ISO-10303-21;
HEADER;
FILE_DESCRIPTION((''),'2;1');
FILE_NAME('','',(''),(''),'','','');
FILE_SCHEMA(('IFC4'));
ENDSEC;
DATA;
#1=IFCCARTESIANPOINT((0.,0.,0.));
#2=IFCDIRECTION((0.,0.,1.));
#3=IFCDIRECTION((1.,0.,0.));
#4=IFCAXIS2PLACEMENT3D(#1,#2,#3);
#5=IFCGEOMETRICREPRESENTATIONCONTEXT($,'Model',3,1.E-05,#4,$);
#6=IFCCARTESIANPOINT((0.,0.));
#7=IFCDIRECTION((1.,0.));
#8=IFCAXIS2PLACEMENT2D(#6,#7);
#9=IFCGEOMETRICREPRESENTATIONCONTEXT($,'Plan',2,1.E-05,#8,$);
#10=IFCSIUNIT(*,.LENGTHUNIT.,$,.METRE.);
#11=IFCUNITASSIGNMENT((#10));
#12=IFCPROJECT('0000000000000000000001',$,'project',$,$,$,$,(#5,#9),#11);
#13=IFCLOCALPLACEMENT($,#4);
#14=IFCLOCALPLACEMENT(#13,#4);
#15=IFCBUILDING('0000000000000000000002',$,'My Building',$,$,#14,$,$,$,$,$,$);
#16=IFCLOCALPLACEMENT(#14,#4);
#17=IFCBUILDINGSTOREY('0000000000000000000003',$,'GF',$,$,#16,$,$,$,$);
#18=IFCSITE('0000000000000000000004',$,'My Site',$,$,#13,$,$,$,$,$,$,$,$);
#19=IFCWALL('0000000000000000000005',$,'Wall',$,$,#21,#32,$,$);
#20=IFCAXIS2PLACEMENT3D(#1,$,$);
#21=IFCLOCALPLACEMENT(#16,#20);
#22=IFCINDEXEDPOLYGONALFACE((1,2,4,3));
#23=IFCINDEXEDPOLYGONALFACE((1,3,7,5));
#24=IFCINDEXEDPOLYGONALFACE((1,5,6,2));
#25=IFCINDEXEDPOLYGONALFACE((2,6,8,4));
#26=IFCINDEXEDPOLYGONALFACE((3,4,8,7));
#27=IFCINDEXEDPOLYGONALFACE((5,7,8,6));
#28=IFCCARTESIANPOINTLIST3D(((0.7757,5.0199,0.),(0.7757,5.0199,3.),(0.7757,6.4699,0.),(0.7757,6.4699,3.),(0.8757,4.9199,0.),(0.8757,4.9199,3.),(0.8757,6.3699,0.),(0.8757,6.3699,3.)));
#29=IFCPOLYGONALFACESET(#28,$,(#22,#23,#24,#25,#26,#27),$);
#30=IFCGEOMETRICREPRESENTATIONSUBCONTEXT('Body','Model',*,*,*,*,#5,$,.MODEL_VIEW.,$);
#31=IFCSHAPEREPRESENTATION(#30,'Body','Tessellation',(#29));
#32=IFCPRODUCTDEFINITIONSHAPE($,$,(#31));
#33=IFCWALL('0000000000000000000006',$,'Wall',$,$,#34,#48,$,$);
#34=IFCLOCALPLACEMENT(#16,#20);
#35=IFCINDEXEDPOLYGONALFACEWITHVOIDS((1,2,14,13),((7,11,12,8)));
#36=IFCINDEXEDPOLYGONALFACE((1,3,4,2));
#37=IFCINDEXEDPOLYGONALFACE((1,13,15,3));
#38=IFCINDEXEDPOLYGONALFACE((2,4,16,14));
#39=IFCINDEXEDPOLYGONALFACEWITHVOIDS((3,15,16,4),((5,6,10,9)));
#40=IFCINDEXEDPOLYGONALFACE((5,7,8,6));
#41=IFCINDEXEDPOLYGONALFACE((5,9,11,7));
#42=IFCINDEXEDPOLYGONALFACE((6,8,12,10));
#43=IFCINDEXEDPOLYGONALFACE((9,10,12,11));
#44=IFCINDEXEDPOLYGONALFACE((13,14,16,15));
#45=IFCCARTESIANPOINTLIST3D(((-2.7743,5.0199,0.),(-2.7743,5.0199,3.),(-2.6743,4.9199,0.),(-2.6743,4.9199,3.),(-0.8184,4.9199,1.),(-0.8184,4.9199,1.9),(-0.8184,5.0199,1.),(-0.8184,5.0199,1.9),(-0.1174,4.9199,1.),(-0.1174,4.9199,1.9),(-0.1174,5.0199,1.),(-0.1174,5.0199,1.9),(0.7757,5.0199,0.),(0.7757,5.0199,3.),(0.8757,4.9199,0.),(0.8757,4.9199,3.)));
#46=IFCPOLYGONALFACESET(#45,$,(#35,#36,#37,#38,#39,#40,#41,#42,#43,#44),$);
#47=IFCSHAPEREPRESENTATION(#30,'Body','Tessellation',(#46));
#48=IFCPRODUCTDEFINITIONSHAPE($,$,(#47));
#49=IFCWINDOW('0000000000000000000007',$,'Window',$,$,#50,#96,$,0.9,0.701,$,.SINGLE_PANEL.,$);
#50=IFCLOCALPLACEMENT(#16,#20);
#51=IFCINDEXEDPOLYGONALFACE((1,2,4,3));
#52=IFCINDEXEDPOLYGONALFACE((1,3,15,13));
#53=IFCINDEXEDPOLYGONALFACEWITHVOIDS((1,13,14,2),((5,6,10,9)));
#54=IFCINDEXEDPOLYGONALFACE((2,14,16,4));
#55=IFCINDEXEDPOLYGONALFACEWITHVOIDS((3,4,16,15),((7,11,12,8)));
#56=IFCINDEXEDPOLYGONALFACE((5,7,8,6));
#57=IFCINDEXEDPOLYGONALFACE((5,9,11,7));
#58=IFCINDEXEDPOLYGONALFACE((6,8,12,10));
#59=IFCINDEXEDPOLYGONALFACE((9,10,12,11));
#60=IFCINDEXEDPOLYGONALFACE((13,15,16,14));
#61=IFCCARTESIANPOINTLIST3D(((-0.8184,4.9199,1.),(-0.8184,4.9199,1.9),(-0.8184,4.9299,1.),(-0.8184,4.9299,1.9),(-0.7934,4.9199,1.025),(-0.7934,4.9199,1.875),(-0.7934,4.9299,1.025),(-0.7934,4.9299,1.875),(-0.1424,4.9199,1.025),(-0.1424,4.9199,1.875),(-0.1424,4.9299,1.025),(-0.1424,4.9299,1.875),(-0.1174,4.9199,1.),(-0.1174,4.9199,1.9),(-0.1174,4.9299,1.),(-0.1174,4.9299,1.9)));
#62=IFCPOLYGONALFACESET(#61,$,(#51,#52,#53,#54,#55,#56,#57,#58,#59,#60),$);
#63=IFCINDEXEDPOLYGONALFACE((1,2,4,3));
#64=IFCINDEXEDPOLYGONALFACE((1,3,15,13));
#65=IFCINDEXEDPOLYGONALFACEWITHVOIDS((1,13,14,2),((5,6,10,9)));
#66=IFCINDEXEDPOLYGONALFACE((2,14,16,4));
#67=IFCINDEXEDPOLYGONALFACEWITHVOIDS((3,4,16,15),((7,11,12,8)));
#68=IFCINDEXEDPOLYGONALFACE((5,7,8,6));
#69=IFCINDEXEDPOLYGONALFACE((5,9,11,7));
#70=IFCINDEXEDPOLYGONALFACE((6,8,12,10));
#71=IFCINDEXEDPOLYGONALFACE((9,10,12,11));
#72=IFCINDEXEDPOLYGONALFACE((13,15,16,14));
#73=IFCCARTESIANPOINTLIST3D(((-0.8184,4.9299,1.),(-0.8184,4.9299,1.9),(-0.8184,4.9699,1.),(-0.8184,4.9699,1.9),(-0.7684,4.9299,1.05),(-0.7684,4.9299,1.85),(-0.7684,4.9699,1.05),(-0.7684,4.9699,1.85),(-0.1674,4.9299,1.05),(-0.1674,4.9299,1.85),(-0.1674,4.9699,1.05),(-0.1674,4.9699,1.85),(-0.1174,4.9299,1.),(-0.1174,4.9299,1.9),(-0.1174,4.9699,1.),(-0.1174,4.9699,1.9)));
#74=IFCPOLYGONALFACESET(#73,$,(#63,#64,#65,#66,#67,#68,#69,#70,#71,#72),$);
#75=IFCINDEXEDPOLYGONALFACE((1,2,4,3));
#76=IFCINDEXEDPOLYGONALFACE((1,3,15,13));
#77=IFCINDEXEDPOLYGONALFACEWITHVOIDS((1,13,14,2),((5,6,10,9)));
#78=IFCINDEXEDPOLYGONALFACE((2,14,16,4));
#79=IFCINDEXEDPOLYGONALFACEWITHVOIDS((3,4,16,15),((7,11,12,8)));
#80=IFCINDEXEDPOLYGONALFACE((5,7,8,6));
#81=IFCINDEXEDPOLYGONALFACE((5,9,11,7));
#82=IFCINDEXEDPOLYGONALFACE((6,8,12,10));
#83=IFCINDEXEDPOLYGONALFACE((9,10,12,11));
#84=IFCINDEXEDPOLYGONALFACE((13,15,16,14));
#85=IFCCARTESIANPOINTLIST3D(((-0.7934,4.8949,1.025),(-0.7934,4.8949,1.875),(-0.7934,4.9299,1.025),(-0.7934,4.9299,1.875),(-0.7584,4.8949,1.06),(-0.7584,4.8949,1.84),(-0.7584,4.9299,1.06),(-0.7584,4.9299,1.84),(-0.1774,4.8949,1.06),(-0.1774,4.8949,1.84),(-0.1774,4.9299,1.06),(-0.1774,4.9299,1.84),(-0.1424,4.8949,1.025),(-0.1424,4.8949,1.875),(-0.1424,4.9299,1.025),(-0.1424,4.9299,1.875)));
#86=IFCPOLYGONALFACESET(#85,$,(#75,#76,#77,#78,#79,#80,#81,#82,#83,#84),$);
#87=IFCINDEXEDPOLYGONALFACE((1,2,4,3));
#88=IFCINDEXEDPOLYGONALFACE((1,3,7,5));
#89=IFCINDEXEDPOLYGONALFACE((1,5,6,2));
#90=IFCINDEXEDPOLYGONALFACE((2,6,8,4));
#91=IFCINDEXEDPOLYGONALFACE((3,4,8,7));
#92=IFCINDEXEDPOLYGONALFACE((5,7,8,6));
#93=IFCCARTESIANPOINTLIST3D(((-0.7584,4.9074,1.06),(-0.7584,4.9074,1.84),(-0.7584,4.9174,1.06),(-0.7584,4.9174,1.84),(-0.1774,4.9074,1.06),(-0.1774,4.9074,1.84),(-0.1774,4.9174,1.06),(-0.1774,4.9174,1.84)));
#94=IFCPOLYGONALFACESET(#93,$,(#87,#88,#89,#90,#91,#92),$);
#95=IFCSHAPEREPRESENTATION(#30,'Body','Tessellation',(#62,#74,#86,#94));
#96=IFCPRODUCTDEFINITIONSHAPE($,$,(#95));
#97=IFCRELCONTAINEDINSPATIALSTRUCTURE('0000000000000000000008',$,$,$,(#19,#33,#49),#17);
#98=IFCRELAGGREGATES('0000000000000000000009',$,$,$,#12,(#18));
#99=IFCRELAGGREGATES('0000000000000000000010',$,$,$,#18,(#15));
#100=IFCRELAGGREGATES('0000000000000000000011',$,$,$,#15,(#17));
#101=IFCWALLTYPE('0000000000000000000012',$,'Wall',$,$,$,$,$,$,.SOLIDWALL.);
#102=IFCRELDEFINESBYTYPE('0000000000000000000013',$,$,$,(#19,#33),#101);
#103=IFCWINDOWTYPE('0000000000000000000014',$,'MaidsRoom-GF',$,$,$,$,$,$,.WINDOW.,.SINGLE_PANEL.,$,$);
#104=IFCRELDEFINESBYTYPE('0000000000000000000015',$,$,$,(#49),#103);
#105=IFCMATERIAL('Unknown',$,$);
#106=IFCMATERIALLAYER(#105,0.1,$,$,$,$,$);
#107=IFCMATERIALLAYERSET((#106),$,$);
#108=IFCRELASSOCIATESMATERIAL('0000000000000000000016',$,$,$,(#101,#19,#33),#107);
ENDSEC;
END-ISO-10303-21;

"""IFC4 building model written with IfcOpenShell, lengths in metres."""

from ifc_helpers import new_model, entity, si_unit, frame, origin_with_axes, origin_2d_with_axis, place, context, subcontext, project, spatial, line, indexed_curve, outline, extrude, shape, source, transform, mapped, material, layer, layer_set, layer_usage, type_object, type_shapes, element, fill, save


model = new_model("IFC4")

# Units and contexts
model_context = context("Model", 3, precision=1e-05, world=origin_with_axes())
plan_context = context("Plan", 2, precision=1e-05, world=origin_2d_with_axis())
body_context_1 = subcontext(model_context, "Body", "Model", "MODEL_VIEW")
body_context_2 = subcontext(plan_context, "Body", "Plan", "PLAN_VIEW")
ifc_project = project(units=[si_unit("LENGTHUNIT", "METRE")], contexts=[model_context, plan_context])

# Site, building, storey
site_placement = place(None, origin_with_axes())
site = spatial("IfcSite", under=ifc_project, at=site_placement, Name="My Site")
building_placement = place(site_placement, origin_with_axes())
building = spatial("IfcBuilding", under=site, at=building_placement, Name="My Building")
storey_placement = place(building_placement, origin_with_axes())
storey = spatial("IfcBuildingStorey", under=building, at=storey_placement, Name="GF")

# Shared definitions
ifc_material_1 = material(Name="Unknown")

# Wall
ifc_layer_1 = layer(ifc_material_1, 0.1)
ifc_layer_set_1 = layer_set([ifc_layer_1])
wall_type = type_object("IfcWallType", Name="Wall", PredefinedType="SOLIDWALL", material=ifc_layer_set_1)
ifc_layer_usage_1 = layer_usage(ifc_layer_set_1, "AXIS2", "POSITIVE", 0.0)
wall_1_placement = place(storey_placement, frame((0.7757, 6.4699, 0.0), z_axis=(0.0, 0.0, 1.0), x_axis=(0.0, -1.0, 0.0)))
element("IfcWall", 1, at=wall_1_placement, inside=storey, type_object=wall_type, material=ifc_layer_usage_1, Name="Wall", context=body_context_1, shape_type="SweptSolid", body=[
    extrude(outline(indexed_curve([(0.0, 0.0), (0.1, 0.1), (1.55, 0.1), (1.45, 0.0)], segments=[line(1, 2, 3, 4, 1)])), origin_with_axes(), (0.0, 0.0, 1.0), 3.0),
])

# Wall, opening, window
ifc_layer_usage_2 = layer_usage(ifc_layer_set_1, "AXIS2", "POSITIVE", 0.0)
wall_2_placement = place(storey_placement, frame((0.7757, 5.0199, 0.0), z_axis=(0.0, 0.0, 1.0), x_axis=(-1.0, 0.0, 0.0)))
wall_2 = element("IfcWall", 2, at=wall_2_placement, inside=storey, type_object=wall_type, material=ifc_layer_usage_2, Name="Wall", context=body_context_1, shape_type="SweptSolid", body=[
    extrude(outline(indexed_curve([(0.0, 0.0), (-0.1, 0.1), (3.45, 0.1), (3.55, 0.0)], segments=[line(1, 2, 3, 4, 1)])), origin_with_axes(), (0.0, 0.0, 1.0), 3.0),
])
shared_shape_1 = source(origin_with_axes(), body_context_1, "Body", "SweptSolid", [
    extrude(outline(indexed_curve([(0.0, 0.0), (0.701, 0.0), (0.701, 0.9), (0.0, 0.9)], segments=[line(1, 2, 3, 4, 1)])), frame((0.0, -0.6, 0.0), z_axis=(0.0, -1.0, 0.0), x_axis=(1.0, 0.0, 0.0)), (0.0, 0.0, -1.0), 1.2),
])
opening_1_placement = place(wall_2_placement, frame((0.8931, 0.0, 1.0), z_axis=(0.0, 0.0, 1.0), x_axis=(1.0, 0.0, 0.0)))
opening_1 = element("IfcOpeningElement", 3, at=opening_1_placement, cuts=wall_2, PredefinedType="OPENING", context=body_context_1, shape_type="MappedRepresentation", body=[
    mapped(shared_shape_1, transform((0.0, 0.0, 0.0), x_axis=(1.0, 0.0, 0.0), y_axis=(0.0, 1.0, 0.0), z_axis=(0.0, 0.0, 1.0), scale=1.0)),
])
window_type_1 = type_object("IfcWindowType", Name="MaidsRoom-GF", PartitioningType="SINGLE_PANEL", PredefinedType="WINDOW")
shared_shape_2 = source(origin_with_axes(), body_context_1, "Body", "SweptSolid", [
    extrude(outline(indexed_curve([(0.0, 0.0), (0.701, 0.0), (0.701, 0.9), (0.0, 0.9)], segments=[line(1, 2, 3, 4, 1)]), holes=[indexed_curve([(0.025, 0.025), (0.676, 0.025), (0.676, 0.875), (0.025, 0.875)], segments=[line(1, 2, 3, 4, 1)])]), frame((0.0, 0.09, 0.0), z_axis=(0.0, -1.0, 0.0), x_axis=(1.0, 0.0, 0.0)), (0.0, 0.0, -1.0), 0.01),
    extrude(outline(indexed_curve([(0.0, 0.0), (0.701, 0.0), (0.701, 0.9), (0.0, 0.9)], segments=[line(1, 2, 3, 4, 1)]), holes=[indexed_curve([(0.05, 0.05), (0.651, 0.05), (0.651, 0.85), (0.05, 0.85)], segments=[line(1, 2, 3, 4, 1)])]), frame((0.0, 0.05, 0.0), z_axis=(0.0, -1.0, 0.0), x_axis=(1.0, 0.0, 0.0)), (0.0, 0.0, -1.0), 0.04),
    extrude(outline(indexed_curve([(0.0, 0.0), (0.651, 0.0), (0.651, 0.85), (0.0, 0.85)], segments=[line(1, 2, 3, 4, 1)]), holes=[indexed_curve([(0.035, 0.035), (0.616, 0.035), (0.616, 0.815), (0.035, 0.815)], segments=[line(1, 2, 3, 4, 1)])]), frame((0.025, 0.09, 0.025), z_axis=(0.0, -1.0, 0.0), x_axis=(1.0, 0.0, 0.0)), (0.0, 0.0, -1.0), 0.035),
    extrude(outline(indexed_curve([(0.035, 0.035), (0.616, 0.035), (0.616, 0.815), (0.035, 0.815)], segments=[line(1, 2, 3, 4, 1)])), frame((0.025, 0.1025, 0.025), z_axis=(0.0, -1.0, 0.0), x_axis=(1.0, 0.0, 0.0)), (0.0, 0.0, -1.0), 0.01),
])
shared_shape_3 = source(origin_with_axes(), body_context_2, "Body", "Curve2D", [
    entity("IfcIndexedPolyCurve", entity("IfcCartesianPointList2D", [[0.05, 0.05], [0.651, 0.05]])),
    entity("IfcIndexedPolyCurve", entity("IfcCartesianPointList2D", [[0.0, 0.1], [0.025, 0.1], [0.025, 0.09], [0.05, 0.09], [0.05, 0.05], [0.0, 0.05]]), [entity("IfcLineIndex", [1, 2, 3, 4, 5, 6, 1])]),
    entity("IfcIndexedPolyCurve", entity("IfcCartesianPointList2D", [[0.701, 0.1], [0.676, 0.1], [0.676, 0.09], [0.651, 0.09], [0.651, 0.05], [0.701, 0.05]]), [entity("IfcLineIndex", [1, 2, 3, 4, 5, 6, 1])]),
    entity("IfcIndexedPolyCurve", entity("IfcCartesianPointList2D", [[0.025, 0.09], [0.06, 0.09], [0.06, 0.125], [0.025, 0.125]]), [entity("IfcLineIndex", [1, 2, 3, 4, 1])]),
    entity("IfcIndexedPolyCurve", entity("IfcCartesianPointList2D", [[0.676, 0.09], [0.641, 0.09], [0.641, 0.125], [0.676, 0.125]]), [entity("IfcLineIndex", [1, 2, 3, 4, 1])]),
    entity("IfcIndexedPolyCurve", entity("IfcCartesianPointList2D", [[0.06, 0.09], [0.641, 0.09]])),
    entity("IfcIndexedPolyCurve", entity("IfcCartesianPointList2D", [[0.06, 0.125], [0.641, 0.125]])),
    entity("IfcIndexedPolyCurve", entity("IfcCartesianPointList2D", [[0.06, 0.1075], [0.641, 0.1075]])),
])
type_shapes(window_type_1, [shared_shape_2, shared_shape_3])
window_1_placement = place(opening_1_placement, frame((0.0, 0.0, 0.0), z_axis=(0.0, 0.0, 1.0), x_axis=(1.0, 0.0, 0.0)))
window_1 = element("IfcWindow", 4, at=window_1_placement, inside=storey, type_object=window_type_1, Name="Window", OverallHeight=0.9, OverallWidth=0.701, PartitioningType="SINGLE_PANEL", shapes=[
    shape(body_context_1, "Body", "MappedRepresentation", [mapped(shared_shape_2, transform((0.0, 0.0, 0.0), x_axis=(1.0, 0.0, 0.0), y_axis=(0.0, 1.0, 0.0), z_axis=(0.0, 0.0, 1.0), scale=1.0))]),
    shape(body_context_2, "Body", "MappedRepresentation", [mapped(shared_shape_3, transform((0.0, 0.0, 0.0), x_axis=(1.0, 0.0, 0.0), y_axis=(0.0, 1.0, 0.0), z_axis=(0.0, 0.0, 1.0), scale=1.0))]),
])
fill(opening_1, window_1)

save(model, "model.ifc")
